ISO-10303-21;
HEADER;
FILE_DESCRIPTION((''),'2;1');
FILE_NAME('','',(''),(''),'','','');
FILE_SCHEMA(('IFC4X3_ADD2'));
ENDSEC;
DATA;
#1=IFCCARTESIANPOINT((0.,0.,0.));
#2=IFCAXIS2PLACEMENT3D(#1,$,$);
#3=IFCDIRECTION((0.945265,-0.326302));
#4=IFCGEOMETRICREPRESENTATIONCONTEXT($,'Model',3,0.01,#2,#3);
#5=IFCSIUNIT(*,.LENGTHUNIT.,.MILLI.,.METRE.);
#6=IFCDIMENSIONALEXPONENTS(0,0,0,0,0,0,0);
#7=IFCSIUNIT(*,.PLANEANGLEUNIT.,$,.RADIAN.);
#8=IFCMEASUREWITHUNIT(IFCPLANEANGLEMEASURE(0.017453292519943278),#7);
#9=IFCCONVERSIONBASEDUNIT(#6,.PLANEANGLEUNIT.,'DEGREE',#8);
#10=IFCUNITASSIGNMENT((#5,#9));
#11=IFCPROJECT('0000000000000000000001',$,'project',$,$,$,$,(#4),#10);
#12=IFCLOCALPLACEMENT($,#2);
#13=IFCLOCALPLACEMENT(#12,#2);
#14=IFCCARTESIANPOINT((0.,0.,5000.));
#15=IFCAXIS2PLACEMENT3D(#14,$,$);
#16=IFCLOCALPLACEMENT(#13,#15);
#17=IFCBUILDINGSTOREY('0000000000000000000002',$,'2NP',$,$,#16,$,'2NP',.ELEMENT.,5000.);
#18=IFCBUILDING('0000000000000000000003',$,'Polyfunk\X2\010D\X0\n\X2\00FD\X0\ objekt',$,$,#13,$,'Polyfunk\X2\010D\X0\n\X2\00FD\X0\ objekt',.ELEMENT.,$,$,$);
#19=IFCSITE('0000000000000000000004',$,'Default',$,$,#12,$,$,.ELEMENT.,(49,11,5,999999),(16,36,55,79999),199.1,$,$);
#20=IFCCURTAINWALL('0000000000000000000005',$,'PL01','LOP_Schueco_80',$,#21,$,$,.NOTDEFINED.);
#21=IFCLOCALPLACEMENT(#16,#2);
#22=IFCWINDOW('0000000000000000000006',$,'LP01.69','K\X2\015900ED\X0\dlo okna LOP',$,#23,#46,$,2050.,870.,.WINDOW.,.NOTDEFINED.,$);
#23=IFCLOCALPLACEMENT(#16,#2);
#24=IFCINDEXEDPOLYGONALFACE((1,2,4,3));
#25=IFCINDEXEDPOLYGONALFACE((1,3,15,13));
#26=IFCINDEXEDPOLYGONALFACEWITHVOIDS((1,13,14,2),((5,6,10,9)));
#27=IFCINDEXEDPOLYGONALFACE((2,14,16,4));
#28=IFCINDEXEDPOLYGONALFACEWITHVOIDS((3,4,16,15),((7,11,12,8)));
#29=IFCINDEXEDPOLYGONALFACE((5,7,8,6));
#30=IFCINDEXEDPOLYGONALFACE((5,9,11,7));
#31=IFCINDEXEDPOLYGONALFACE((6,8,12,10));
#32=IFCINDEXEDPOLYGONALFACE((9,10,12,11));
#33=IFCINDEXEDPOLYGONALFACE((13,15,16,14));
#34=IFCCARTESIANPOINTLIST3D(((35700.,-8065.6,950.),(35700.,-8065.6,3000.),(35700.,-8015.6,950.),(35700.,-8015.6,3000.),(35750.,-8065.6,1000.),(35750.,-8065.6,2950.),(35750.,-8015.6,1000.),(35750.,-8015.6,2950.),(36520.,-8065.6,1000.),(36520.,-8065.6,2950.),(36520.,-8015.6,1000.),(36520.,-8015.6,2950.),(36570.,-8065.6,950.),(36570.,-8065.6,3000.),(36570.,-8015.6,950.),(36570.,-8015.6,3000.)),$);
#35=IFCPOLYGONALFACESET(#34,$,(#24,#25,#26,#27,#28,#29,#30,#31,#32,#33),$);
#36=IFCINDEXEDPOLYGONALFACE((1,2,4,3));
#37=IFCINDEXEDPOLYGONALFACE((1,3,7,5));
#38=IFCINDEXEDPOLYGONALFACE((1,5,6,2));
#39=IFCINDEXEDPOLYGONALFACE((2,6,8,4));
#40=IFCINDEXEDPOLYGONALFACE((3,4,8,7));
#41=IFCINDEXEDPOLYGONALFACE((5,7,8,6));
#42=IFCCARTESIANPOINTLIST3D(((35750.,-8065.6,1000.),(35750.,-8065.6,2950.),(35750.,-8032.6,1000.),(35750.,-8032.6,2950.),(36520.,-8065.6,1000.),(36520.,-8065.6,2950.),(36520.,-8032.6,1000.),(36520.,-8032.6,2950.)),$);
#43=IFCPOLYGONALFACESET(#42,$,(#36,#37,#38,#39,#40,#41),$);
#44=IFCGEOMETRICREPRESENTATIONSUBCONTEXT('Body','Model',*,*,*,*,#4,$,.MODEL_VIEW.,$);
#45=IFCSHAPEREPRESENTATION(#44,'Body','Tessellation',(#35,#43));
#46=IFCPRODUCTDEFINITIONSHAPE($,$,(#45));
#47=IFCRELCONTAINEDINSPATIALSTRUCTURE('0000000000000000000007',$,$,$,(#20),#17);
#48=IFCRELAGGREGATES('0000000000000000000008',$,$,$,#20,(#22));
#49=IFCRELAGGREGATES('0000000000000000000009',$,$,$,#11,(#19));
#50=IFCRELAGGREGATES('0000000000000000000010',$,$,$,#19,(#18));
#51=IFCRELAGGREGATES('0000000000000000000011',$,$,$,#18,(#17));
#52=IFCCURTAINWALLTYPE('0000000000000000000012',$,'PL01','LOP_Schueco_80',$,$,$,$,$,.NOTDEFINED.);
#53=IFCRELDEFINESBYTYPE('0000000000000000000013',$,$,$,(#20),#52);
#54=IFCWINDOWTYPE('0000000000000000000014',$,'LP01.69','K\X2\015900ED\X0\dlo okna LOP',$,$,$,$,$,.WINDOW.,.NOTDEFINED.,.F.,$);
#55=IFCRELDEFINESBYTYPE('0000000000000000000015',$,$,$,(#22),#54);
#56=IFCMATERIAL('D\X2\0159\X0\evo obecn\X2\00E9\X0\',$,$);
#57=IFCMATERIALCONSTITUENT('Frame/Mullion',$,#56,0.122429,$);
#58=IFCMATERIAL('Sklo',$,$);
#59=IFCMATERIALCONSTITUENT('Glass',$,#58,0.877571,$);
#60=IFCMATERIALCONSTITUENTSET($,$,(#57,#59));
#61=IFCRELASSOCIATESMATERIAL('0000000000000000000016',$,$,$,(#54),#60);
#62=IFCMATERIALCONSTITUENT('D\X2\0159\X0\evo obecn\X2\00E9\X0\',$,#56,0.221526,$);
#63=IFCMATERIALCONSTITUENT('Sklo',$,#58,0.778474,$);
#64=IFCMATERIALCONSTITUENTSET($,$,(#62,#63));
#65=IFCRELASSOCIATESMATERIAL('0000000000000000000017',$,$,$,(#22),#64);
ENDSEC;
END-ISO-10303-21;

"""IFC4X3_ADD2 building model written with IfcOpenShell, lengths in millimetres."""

from ifc_helpers import new_model, entity, si_unit, converted_unit, direction, frame, frame_2d, origin, place, context, subcontext, project, spatial, polyline, rectangle, outline, extrude, source, transform, mapped, material, constituent, constituent_set, type_object, type_shapes, element, aggregate, save


model = new_model("IFC4X3_ADD2")

# Units and contexts
model_context = context("Model", 3, precision=0.01, world=origin(), true_north=direction((0.945265, -0.326302)))
body_context = subcontext(model_context, "Body", "Model", "MODEL_VIEW")
ifc_project = project(units=[si_unit("LENGTHUNIT", "METRE", prefix="MILLI"), converted_unit("PLANEANGLEUNIT", "DEGREE", entity("IfcPlaneAngleMeasure", 0.017453292519943278), si_unit("PLANEANGLEUNIT", "RADIAN"), dimensions=[0, 0, 0, 0, 0, 0, 0])], contexts=[model_context])

# Site, building, storey
site_placement = place(None, origin())
site = spatial("IfcSite", under=ifc_project, at=site_placement, Name="Default", CompositionType="ELEMENT", RefLatitude=(49, 11, 5, 999999), RefLongitude=(16, 36, 55, 79999), RefElevation=199.1)
building_placement = place(site_placement, origin())
building = spatial("IfcBuilding", under=site, at=building_placement, Name="Polyfunkčný objekt", LongName="Polyfunkčný objekt", CompositionType="ELEMENT")
storey_placement = place(building_placement, frame((0.0, 0.0, 5000.0)))
storey = spatial("IfcBuildingStorey", under=building, at=storey_placement, Name="2NP", LongName="2NP", CompositionType="ELEMENT", Elevation=5000.0)

# Curtain wall
curtain_wall_type = type_object("IfcCurtainWallType", Name="PL01", Description="LOP_Schueco_80", PredefinedType="NOTDEFINED")
curtain_wall_placement = place(storey_placement, frame((0.0, 0.0, -5000.0)))
curtain_wall = element("IfcCurtainWall", 1, at=curtain_wall_placement, inside=storey, type_object=curtain_wall_type, Name="PL01", Description="LOP_Schueco_80", PredefinedType="NOTDEFINED")
ifc_material_1 = material(Name="Sklo")

# Window
ifc_material_2 = material(Name="Dřevo obecné")
ifc_constituent_1 = constituent(ifc_material_2, Name="Dřevo obecné", fraction=0.221526)
ifc_constituent_2 = constituent(ifc_material_1, Name="Sklo", fraction=0.778474)
ifc_constituent_set_1 = constituent_set(constituents=[ifc_constituent_1, ifc_constituent_2])
ifc_constituent_3 = constituent(ifc_material_2, Name="Frame/Mullion", fraction=0.122429)
ifc_constituent_4 = constituent(ifc_material_1, Name="Glass", fraction=0.877571)
ifc_constituent_set_2 = constituent_set(constituents=[ifc_constituent_3, ifc_constituent_4])
window_type = type_object("IfcWindowType", Name="LP01.69", Description="Křídlo okna LOP", ParameterTakesPrecedence=False, PartitioningType="NOTDEFINED", PredefinedType="WINDOW", material=ifc_constituent_set_2)
shared_shape_1 = source(origin(), body_context, "Body", "SweptSolid", [
    extrude(outline(polyline([(-1025.0, -435.0), (1025.0, -435.0), (1025.0, 435.0), (-1025.0, 435.0), (-1025.0, -435.0)]), holes=[polyline([(-975.0, -385.0), (-975.0, 385.0), (975.0, 385.0), (975.0, -385.0), (-975.0, -385.0)])]), frame((0.0, 50.0, 1025.0), z_axis=(0.0, -1.0, 0.0), x_axis=(0.0, 0.0, -1.0)), (0.0, 0.0, 1.0), 50.0),
    extrude(rectangle(XDim=770.0, YDim=33.0, at=frame_2d((0.0, 0.0), x_axis=(1.0, 0.0))), frame((0.0, 33.5, 50.0), z_axis=(0.0, 0.0, 1.0), x_axis=(-1.0, 0.0, 0.0)), (0.0, 0.0, 1.0), 1950.0),
])
type_shapes(window_type, [shared_shape_1])
window_placement = place(curtain_wall_placement, frame((36135.0, -8015.6, 5950.0), z_axis=(0.0, 0.0, 1.0), x_axis=(-1.0, 0.0, 0.0)))
window = element("IfcWindow", 2, at=window_placement, type_object=window_type, material=ifc_constituent_set_1, Name="LP01.69", Description="Křídlo okna LOP", OverallHeight=2050.0, OverallWidth=870.0, PartitioningType="NOTDEFINED", PredefinedType="WINDOW", context=body_context, shape_type="MappedRepresentation", body=[
    mapped(shared_shape_1, transform((0.0, 0.0, 0.0), scale=1.0)),
])
aggregate(curtain_wall, [window])

save(model, "model.ifc")
